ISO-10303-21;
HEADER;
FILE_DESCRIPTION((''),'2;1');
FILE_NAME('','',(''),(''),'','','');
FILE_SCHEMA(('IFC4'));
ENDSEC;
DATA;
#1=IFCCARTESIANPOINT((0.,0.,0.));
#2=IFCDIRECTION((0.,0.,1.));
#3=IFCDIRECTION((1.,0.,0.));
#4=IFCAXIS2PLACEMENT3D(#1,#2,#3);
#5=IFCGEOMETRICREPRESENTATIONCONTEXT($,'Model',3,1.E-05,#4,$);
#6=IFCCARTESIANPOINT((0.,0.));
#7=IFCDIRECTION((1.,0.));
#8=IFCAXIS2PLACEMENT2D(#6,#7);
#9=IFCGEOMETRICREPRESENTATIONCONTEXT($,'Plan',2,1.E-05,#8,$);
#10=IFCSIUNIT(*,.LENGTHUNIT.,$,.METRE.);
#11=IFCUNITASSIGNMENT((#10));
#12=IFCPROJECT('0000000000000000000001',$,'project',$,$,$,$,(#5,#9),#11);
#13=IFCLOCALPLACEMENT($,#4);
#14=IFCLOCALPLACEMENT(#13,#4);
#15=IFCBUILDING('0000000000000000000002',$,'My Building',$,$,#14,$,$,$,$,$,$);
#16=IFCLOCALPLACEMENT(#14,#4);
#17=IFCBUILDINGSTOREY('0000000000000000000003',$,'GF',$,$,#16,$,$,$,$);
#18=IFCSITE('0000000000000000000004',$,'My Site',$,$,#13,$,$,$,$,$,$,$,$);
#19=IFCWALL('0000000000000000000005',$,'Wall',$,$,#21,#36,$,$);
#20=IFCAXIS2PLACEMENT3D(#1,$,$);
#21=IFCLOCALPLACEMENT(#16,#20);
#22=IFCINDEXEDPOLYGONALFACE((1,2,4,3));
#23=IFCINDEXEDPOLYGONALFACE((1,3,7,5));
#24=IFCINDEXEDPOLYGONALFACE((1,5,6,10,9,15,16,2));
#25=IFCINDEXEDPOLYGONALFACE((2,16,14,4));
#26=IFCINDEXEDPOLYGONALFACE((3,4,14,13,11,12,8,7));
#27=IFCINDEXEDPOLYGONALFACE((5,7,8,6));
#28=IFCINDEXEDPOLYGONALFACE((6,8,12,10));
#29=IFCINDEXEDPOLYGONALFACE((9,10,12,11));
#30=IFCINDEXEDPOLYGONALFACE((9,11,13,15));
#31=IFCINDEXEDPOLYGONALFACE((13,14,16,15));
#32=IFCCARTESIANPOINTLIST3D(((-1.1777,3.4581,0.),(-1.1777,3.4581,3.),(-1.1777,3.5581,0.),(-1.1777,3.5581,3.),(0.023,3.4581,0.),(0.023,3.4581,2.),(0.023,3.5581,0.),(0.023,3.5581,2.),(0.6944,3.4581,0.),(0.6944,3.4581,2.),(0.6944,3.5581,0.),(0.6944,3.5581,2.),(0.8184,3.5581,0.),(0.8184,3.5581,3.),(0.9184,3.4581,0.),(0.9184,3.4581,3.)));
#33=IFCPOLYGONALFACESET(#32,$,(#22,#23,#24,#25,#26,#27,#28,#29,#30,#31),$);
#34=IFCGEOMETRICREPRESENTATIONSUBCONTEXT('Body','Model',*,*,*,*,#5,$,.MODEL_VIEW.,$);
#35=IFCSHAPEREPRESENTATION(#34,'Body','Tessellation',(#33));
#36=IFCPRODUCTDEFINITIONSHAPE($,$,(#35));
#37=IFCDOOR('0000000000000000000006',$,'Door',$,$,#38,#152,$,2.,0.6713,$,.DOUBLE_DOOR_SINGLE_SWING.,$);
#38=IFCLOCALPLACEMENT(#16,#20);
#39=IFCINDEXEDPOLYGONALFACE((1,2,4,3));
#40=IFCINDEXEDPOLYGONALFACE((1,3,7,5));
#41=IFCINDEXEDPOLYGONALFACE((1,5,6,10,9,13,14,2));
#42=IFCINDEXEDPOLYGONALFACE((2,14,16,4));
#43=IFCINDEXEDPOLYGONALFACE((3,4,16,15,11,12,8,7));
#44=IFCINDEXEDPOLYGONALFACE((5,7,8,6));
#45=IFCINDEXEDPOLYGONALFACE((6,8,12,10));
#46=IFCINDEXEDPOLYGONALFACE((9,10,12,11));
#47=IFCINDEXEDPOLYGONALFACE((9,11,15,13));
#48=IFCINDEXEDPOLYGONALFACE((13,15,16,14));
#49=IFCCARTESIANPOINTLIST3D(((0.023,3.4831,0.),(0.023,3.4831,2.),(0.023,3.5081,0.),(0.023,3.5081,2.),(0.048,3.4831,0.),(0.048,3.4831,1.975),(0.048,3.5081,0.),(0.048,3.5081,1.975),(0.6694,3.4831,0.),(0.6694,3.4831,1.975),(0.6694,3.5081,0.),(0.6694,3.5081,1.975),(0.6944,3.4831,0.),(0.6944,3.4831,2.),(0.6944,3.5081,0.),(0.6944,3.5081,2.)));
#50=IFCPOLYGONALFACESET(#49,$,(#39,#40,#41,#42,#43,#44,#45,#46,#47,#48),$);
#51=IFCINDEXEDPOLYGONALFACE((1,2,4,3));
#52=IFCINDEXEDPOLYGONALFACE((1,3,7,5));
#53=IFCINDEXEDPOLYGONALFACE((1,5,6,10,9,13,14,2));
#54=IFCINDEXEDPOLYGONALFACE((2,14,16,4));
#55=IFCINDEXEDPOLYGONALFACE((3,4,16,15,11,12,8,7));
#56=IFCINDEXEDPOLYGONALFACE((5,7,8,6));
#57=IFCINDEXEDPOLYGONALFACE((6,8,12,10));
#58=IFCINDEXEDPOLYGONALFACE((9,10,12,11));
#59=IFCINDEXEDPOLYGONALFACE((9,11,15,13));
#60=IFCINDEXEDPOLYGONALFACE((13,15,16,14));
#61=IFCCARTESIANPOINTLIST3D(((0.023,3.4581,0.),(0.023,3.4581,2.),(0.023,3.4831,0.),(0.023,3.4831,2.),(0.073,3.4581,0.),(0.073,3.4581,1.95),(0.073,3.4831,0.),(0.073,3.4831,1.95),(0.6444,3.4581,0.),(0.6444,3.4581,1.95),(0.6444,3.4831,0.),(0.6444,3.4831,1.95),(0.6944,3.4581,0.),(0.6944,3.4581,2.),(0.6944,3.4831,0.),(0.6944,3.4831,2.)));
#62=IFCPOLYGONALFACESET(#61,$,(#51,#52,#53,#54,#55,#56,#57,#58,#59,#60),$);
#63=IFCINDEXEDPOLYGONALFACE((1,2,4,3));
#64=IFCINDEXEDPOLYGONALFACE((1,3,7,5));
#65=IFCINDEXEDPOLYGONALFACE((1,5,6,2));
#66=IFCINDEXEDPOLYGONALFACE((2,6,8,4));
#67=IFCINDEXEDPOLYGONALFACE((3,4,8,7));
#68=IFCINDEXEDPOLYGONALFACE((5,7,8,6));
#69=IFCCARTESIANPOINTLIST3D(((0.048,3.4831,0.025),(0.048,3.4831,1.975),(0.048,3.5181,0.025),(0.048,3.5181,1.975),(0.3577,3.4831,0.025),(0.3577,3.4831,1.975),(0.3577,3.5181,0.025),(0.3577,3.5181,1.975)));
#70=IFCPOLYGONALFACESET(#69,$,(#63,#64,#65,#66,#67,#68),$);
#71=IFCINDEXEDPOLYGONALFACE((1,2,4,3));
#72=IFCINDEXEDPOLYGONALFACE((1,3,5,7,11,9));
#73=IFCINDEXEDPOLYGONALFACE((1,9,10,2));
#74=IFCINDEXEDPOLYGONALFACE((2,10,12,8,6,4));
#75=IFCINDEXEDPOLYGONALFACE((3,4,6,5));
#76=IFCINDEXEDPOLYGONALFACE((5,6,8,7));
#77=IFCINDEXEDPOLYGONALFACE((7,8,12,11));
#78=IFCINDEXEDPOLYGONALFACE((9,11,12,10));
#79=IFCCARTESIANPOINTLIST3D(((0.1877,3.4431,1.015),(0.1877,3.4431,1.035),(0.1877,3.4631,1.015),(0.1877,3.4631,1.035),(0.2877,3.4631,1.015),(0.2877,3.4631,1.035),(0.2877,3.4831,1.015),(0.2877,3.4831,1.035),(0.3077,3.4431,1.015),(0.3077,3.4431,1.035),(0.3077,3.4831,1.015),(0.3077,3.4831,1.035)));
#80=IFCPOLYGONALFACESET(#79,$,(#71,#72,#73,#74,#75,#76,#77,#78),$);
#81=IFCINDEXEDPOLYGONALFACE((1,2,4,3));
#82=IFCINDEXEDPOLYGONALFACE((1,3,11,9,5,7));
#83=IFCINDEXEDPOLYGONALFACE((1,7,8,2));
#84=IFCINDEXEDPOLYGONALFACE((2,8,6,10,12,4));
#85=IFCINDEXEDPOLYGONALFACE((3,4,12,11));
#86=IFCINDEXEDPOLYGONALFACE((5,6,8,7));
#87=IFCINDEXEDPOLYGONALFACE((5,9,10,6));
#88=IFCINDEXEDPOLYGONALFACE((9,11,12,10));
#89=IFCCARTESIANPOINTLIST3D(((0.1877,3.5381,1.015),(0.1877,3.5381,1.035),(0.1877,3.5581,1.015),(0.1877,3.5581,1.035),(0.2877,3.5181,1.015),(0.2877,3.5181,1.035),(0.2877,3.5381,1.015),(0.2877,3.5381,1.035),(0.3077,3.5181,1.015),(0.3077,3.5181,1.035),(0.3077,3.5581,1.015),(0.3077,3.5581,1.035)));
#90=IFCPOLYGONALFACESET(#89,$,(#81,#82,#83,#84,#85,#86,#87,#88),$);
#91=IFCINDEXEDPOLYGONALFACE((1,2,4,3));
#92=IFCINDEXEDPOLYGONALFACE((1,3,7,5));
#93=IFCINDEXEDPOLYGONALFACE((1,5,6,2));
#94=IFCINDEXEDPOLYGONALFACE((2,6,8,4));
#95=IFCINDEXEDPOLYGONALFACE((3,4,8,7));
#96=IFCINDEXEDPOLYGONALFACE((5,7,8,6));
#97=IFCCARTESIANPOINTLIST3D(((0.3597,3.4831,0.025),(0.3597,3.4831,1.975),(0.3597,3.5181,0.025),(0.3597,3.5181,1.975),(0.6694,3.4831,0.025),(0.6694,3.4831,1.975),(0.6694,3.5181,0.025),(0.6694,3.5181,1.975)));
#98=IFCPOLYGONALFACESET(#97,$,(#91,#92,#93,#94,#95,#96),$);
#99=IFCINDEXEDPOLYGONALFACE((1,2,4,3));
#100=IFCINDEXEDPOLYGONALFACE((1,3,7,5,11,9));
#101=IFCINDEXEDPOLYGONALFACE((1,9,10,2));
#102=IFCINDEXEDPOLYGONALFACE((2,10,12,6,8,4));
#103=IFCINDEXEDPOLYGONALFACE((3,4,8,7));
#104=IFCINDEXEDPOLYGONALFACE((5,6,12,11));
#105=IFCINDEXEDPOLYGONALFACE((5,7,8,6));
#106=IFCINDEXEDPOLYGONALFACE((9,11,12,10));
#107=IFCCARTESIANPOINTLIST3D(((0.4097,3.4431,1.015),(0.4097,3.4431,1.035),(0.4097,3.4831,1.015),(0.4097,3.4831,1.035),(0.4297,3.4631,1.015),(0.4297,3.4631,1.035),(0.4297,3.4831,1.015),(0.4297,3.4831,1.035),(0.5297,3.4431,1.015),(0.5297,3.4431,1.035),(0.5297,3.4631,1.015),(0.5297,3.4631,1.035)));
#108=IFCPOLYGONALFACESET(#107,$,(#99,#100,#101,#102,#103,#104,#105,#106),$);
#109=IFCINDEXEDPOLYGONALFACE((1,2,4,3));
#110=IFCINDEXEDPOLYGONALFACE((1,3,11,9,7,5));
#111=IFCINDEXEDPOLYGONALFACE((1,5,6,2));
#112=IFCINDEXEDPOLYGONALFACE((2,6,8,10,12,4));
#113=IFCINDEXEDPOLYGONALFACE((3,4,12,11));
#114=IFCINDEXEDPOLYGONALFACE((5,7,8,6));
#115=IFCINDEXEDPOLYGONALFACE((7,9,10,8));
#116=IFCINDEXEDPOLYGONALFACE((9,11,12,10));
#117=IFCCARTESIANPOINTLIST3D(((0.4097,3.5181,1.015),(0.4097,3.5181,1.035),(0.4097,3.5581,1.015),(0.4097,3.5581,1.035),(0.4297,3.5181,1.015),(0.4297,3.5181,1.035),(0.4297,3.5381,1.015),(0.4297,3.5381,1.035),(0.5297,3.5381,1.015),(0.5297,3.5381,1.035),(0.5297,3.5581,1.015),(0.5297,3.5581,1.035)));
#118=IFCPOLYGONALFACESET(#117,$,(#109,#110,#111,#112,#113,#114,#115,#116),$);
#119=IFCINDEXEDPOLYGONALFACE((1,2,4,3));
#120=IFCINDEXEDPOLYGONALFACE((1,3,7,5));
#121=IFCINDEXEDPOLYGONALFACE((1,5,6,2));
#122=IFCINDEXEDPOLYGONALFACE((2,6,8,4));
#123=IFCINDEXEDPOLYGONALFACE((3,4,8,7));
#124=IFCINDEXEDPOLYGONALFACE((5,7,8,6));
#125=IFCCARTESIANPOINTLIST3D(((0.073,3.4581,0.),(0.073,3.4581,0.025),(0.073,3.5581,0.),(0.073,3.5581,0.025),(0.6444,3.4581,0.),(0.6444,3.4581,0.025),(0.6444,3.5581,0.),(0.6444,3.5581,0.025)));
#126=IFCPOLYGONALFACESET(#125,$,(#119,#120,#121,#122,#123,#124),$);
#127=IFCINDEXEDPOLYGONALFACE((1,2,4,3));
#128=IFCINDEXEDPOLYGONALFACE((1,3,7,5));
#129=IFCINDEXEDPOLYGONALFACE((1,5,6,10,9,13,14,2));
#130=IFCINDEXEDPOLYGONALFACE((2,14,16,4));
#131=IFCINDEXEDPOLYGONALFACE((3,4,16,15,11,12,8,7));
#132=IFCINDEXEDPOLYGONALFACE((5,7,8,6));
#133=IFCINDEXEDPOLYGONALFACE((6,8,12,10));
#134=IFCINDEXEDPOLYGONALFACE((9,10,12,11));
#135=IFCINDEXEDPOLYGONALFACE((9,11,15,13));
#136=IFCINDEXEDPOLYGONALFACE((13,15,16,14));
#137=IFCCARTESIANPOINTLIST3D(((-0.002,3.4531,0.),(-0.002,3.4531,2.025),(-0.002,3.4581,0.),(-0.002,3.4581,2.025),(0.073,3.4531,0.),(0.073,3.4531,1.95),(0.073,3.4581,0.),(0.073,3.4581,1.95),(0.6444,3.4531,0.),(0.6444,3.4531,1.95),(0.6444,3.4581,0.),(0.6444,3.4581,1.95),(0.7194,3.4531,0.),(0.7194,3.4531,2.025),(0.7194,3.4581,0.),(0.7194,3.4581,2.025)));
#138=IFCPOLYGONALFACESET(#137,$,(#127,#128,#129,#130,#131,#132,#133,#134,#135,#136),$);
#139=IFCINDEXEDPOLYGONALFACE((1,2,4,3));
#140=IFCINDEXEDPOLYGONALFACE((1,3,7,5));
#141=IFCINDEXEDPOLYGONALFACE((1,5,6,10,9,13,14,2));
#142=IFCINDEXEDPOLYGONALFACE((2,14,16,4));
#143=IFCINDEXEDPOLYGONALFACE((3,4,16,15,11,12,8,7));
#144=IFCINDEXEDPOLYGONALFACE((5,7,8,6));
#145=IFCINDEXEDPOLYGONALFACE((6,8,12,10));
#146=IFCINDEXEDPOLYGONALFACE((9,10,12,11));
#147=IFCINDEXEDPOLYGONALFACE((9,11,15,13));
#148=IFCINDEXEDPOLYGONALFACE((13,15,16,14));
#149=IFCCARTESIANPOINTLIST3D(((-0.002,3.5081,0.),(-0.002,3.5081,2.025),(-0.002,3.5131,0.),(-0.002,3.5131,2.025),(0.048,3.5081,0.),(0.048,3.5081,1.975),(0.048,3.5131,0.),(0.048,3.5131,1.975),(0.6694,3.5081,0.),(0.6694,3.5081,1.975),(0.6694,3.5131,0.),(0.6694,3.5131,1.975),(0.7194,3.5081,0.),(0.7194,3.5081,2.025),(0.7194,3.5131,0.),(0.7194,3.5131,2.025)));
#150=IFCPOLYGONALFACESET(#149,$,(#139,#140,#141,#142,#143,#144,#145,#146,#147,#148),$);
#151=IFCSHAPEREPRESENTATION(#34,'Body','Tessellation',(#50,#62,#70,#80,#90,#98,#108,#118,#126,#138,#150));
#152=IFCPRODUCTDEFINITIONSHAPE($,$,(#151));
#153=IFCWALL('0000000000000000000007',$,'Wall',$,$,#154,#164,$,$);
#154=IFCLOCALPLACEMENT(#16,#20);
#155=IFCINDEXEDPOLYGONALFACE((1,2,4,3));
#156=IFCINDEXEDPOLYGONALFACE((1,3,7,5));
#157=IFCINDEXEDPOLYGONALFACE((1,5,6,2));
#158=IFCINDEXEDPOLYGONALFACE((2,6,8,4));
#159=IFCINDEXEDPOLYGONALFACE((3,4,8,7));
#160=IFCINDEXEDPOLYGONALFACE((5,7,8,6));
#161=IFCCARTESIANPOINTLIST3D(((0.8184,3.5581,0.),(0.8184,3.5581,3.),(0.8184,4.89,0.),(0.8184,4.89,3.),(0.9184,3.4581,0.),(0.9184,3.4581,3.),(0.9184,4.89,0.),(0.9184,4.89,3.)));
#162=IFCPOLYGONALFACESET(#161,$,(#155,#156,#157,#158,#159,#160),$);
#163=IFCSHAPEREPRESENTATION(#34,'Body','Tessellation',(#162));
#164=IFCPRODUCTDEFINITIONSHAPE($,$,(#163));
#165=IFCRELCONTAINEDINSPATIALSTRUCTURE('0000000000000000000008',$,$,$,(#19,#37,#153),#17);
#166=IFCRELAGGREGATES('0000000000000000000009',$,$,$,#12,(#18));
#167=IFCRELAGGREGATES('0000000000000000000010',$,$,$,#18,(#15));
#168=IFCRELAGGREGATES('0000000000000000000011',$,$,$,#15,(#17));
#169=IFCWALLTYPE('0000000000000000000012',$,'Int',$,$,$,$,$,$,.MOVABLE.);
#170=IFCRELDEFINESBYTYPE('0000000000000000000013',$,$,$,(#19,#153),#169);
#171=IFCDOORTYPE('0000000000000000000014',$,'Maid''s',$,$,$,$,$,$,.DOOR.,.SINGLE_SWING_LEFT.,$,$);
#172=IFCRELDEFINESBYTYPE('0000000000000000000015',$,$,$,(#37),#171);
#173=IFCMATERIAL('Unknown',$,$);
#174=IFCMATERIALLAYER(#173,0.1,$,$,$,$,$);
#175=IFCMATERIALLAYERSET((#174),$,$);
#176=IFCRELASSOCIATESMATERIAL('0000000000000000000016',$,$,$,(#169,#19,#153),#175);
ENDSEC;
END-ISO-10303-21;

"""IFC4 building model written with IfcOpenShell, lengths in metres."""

from ifc_helpers import new_model, entity, si_unit, frame, origin_with_axes, origin_2d_with_axis, place, context, subcontext, project, spatial, line, indexed_curve, outline, extrude, shape, source, transform, mapped, material, layer, layer_set, layer_usage, type_object, type_shapes, element, fill, save


model = new_model("IFC4")

# Units and contexts
model_context = context("Model", 3, precision=1e-05, world=origin_with_axes())
plan_context = context("Plan", 2, precision=1e-05, world=origin_2d_with_axis())
body_context_1 = subcontext(model_context, "Body", "Model", "MODEL_VIEW")
body_context_2 = subcontext(plan_context, "Body", "Plan", "PLAN_VIEW")
ifc_project = project(units=[si_unit("LENGTHUNIT", "METRE")], contexts=[model_context, plan_context])

# Site, building, storey
site_placement = place(None, origin_with_axes())
site = spatial("IfcSite", under=ifc_project, at=site_placement, Name="My Site")
building_placement = place(site_placement, origin_with_axes())
building = spatial("IfcBuilding", under=site, at=building_placement, Name="My Building")
storey_placement = place(building_placement, origin_with_axes())
storey = spatial("IfcBuildingStorey", under=building, at=storey_placement, Name="GF")

# Shared definitions
ifc_material = material(Name="Unknown")

# Wall, opening, door
ifc_layer_1 = layer(ifc_material, 0.1)
ifc_layer_set_1 = layer_set([ifc_layer_1])
wall_type_1 = type_object("IfcWallType", Name="Int", PredefinedType="MOVABLE", material=ifc_layer_set_1)
ifc_layer_usage_1 = layer_usage(ifc_layer_set_1, "AXIS2", "POSITIVE", 0.0)
wall_1_placement = place(storey_placement, frame((-1.1777, 3.4581, 0.0), z_axis=(0.0, 0.0, 1.0), x_axis=(1.0, 0.0, 0.0)))
wall_1 = element("IfcWall", 1, at=wall_1_placement, inside=storey, type_object=wall_type_1, material=ifc_layer_usage_1, Name="Wall", context=body_context_1, shape_type="SweptSolid", body=[
    extrude(outline(indexed_curve([(0.0, 0.0), (0.0, 0.1), (1.9961, 0.1), (2.0961, 0.0)], segments=[line(1, 2, 3, 4, 1)])), origin_with_axes(), (0.0, 0.0, 1.0), 3.0),
])
shared_shape_1 = source(origin_with_axes(), body_context_1, "Body", "SweptSolid", [
    extrude(outline(indexed_curve([(0.0, 0.0), (0.6713, 0.0), (0.6713, 2.0), (0.0, 2.0)], segments=[line(1, 2, 3, 4, 1)])), frame((0.0, -0.6, 0.0), z_axis=(0.0, -1.0, 0.0), x_axis=(1.0, 0.0, 0.0)), (0.0, 0.0, -1.0), 1.2),
])
opening_1_placement = place(wall_1_placement, frame((1.2007, 0.0, 0.0), z_axis=(0.0, 0.0, 1.0), x_axis=(1.0, 0.0, 0.0)))
opening_1 = element("IfcOpeningElement", 2, at=opening_1_placement, cuts=wall_1, PredefinedType="OPENING", context=body_context_1, shape_type="MappedRepresentation", body=[
    mapped(shared_shape_1, transform((0.0, 0.0, 0.0), x_axis=(1.0, 0.0, 0.0), y_axis=(0.0, 1.0, 0.0), z_axis=(0.0, 0.0, 1.0), scale=1.0)),
])
door_type_1 = type_object("IfcDoorType", Name="Maid's", OperationType="SINGLE_SWING_LEFT", PredefinedType="DOOR")
shared_shape_2 = source(origin_with_axes(), body_context_1, "Body", "SweptSolid", [
    extrude(outline(indexed_curve([(0.0, 0.0), (0.0, 2.0), (0.6713, 2.0), (0.6713, 0.0), (0.6463, 0.0), (0.6463, 1.975), (0.025, 1.975), (0.025, 0.0)], segments=[line(1, 2, 3, 4, 5, 6, 7, 8, 1)])), frame((0.0, 0.025, 0.0), z_axis=(0.0, -1.0, 0.0), x_axis=(1.0, 0.0, 0.0)), (0.0, 0.0, -1.0), 0.025),
    extrude(outline(indexed_curve([(0.0, 0.0), (0.0, 2.0), (0.6713, 2.0), (0.6713, 0.0), (0.6213, 0.0), (0.6213, 1.95), (0.05, 1.95), (0.05, 0.0)], segments=[line(1, 2, 3, 4, 5, 6, 7, 8, 1)])), frame((0.0, 0.0, 0.0), z_axis=(0.0, -1.0, 0.0), x_axis=(1.0, 0.0, 0.0)), (0.0, 0.0, -1.0), 0.025),
    extrude(outline(indexed_curve([(0.0, 0.0), (0.3097, 0.0), (0.3097, 0.035), (0.0, 0.035)], segments=[line(1, 2, 3, 4, 1)])), frame((0.025, 0.025, 0.025), z_axis=(0.0, 0.0, 1.0), x_axis=(1.0, 0.0, 0.0)), (0.0, 0.0, 1.0), 1.95),
    extrude(outline(indexed_curve([(0.0, 0.0), (0.0, -0.04), (-0.12, -0.04), (-0.12, -0.02), (-0.02, -0.02), (-0.02, 0.0)], segments=[line(1, 2, 3, 4, 5, 6, 1)])), frame((0.2847, 0.025, 1.015), z_axis=(0.0, 0.0, 1.0), x_axis=(1.0, 0.0, 0.0)), (0.0, 0.0, 1.0), 0.02),
    extrude(outline(indexed_curve([(0.0, 0.0), (0.0, 0.04), (-0.12, 0.04), (-0.12, 0.02), (-0.02, 0.02), (-0.02, 0.0)], segments=[line(1, 2, 3, 4, 5, 6, 1)])), frame((0.2847, 0.06, 1.015), z_axis=(0.0, 0.0, 1.0), x_axis=(1.0, 0.0, 0.0)), (0.0, 0.0, 1.0), 0.02),
    extrude(outline(indexed_curve([(0.0, 0.0), (-0.3097, 0.0), (-0.3097, 0.035), (0.0, 0.035)], segments=[line(1, 2, 3, 4, 1)])), frame((0.6463, 0.025, 0.025), z_axis=(0.0, 0.0, 1.0), x_axis=(1.0, 0.0, 0.0)), (0.0, 0.0, 1.0), 1.95),
    extrude(outline(indexed_curve([(0.0, 0.0), (0.0, -0.04), (0.12, -0.04), (0.12, -0.02), (0.02, -0.02), (0.02, 0.0)], segments=[line(1, 2, 3, 4, 5, 6, 1)])), frame((0.3867, 0.025, 1.015), z_axis=(0.0, 0.0, 1.0), x_axis=(1.0, 0.0, 0.0)), (0.0, 0.0, 1.0), 0.02),
    extrude(outline(indexed_curve([(0.0, 0.0), (0.0, 0.04), (0.12, 0.04), (0.12, 0.02), (0.02, 0.02), (0.02, 0.0)], segments=[line(1, 2, 3, 4, 5, 6, 1)])), frame((0.3867, 0.06, 1.015), z_axis=(0.0, 0.0, 1.0), x_axis=(1.0, 0.0, 0.0)), (0.0, 0.0, 1.0), 0.02),
    extrude(outline(indexed_curve([(0.0, 0.0), (0.5713, 0.0), (0.5713, 0.1), (0.0, 0.1)], segments=[line(1, 2, 3, 4, 1)])), frame((0.05, 0.0, 0.0), z_axis=(0.0, 0.0, 1.0), x_axis=(1.0, 0.0, 0.0)), (0.0, 0.0, 1.0), 0.025),
    extrude(outline(indexed_curve([(0.0, 0.0), (0.0, 2.025), (0.7213, 2.025), (0.7213, 0.0), (0.6463, 0.0), (0.6463, 1.95), (0.075, 1.95), (0.075, 0.0)], segments=[line(1, 2, 3, 4, 5, 6, 7, 8, 1)])), frame((-0.025, -0.005, 0.0), z_axis=(0.0, -1.0, 0.0), x_axis=(1.0, 0.0, 0.0)), (0.0, 0.0, -1.0), 0.005),
    extrude(outline(indexed_curve([(0.0, 0.0), (0.0, 2.025), (0.7213, 2.025), (0.7213, 0.0), (0.6713, 0.0), (0.6713, 1.975), (0.05, 1.975), (0.05, 0.0)], segments=[line(1, 2, 3, 4, 5, 6, 7, 8, 1)])), frame((-0.025, 0.05, 0.0), z_axis=(0.0, -1.0, 0.0), x_axis=(1.0, 0.0, 0.0)), (0.0, 0.0, -1.0), 0.005),
])
shared_shape_3 = source(origin_with_axes(), body_context_2, "Body", "Curve2D", [
    entity("IfcIndexedPolyCurve", entity("IfcCartesianPointList2D", [[0.0, 0.0], [0.0, 0.05], [0.025, 0.05], [0.025, 0.025], [0.05, 0.025], [0.05, 0.0]]), [entity("IfcLineIndex", [1, 2, 3, 4, 5, 6, 1])]),
    entity("IfcIndexedPolyCurve", entity("IfcCartesianPointList2D", [[0.6713, 0.0], [0.6713, 0.05], [0.6463, 0.05], [0.6463, 0.025], [0.6213, 0.025], [0.6213, 0.0]]), [entity("IfcLineIndex", [1, 2, 3, 4, 5, 6, 1])]),
    entity("IfcTrimmedCurve", entity("IfcEllipse", entity("IfcAxis2Placement2D", entity("IfcCartesianPoint", [0.06, 0.05]), entity("IfcDirection", [1.0, 0.0])), 0.2757, 0.3107), [entity("IfcCartesianPoint", [0.3357, 0.05])], [entity("IfcCartesianPoint", [0.06, 0.3607])], True, "CARTESIAN"),
    entity("IfcIndexedPolyCurve", entity("IfcCartesianPointList2D", [[0.025, 0.05], [0.06, 0.05], [0.06, 0.3607], [0.025, 0.3607]]), [entity("IfcLineIndex", [1, 2, 3, 4, 1])]),
    entity("IfcTrimmedCurve", entity("IfcEllipse", entity("IfcAxis2Placement2D", entity("IfcCartesianPoint", [0.6113, 0.05]), entity("IfcDirection", [1.0, 0.0])), 0.2757, 0.3107), [entity("IfcCartesianPoint", [0.6113, 0.3607])], [entity("IfcCartesianPoint", [0.3357, 0.05])], True, "CARTESIAN"),
    entity("IfcIndexedPolyCurve", entity("IfcCartesianPointList2D", [[0.6463, 0.05], [0.6113, 0.05], [0.6113, 0.3607], [0.6463, 0.3607]]), [entity("IfcLineIndex", [1, 2, 3, 4, 1])]),
])
type_shapes(door_type_1, [shared_shape_2, shared_shape_3])
door_1_placement = place(opening_1_placement, origin_with_axes())
door_1 = element("IfcDoor", 3, at=door_1_placement, inside=storey, type_object=door_type_1, Name="Door", OperationType="DOUBLE_DOOR_SINGLE_SWING", OverallHeight=2.0, OverallWidth=0.6713, shapes=[
    shape(body_context_1, "Body", "MappedRepresentation", [mapped(shared_shape_2, transform((0.0, 0.0, 0.0), x_axis=(1.0, 0.0, 0.0), y_axis=(0.0, 1.0, 0.0), z_axis=(0.0, 0.0, 1.0), scale=1.0))]),
    shape(body_context_2, "Body", "MappedRepresentation", [mapped(shared_shape_3, transform((0.0, 0.0, 0.0), x_axis=(1.0, 0.0, 0.0), y_axis=(0.0, 1.0, 0.0), z_axis=(0.0, 0.0, 1.0), scale=1.0))]),
])
fill(opening_1, door_1)

# Wall
ifc_layer_usage_2 = layer_usage(ifc_layer_set_1, "AXIS2", "POSITIVE", 0.0)
wall_2_placement = place(storey_placement, frame((0.9184, 3.4581, 0.0), z_axis=(0.0, 0.0, 1.0), x_axis=(0.0, 1.0, 0.0)))
element("IfcWall", 4, at=wall_2_placement, inside=storey, type_object=wall_type_1, material=ifc_layer_usage_2, Name="Wall", context=body_context_1, shape_type="SweptSolid", body=[
    extrude(outline(indexed_curve([(0.0, 0.0), (0.1, 0.1), (1.4319, 0.1), (1.4319, 0.0)], segments=[line(1, 2, 3, 4, 1)])), origin_with_axes(), (0.0, 0.0, 1.0), 3.0),
])

save(model, "model.ifc")
